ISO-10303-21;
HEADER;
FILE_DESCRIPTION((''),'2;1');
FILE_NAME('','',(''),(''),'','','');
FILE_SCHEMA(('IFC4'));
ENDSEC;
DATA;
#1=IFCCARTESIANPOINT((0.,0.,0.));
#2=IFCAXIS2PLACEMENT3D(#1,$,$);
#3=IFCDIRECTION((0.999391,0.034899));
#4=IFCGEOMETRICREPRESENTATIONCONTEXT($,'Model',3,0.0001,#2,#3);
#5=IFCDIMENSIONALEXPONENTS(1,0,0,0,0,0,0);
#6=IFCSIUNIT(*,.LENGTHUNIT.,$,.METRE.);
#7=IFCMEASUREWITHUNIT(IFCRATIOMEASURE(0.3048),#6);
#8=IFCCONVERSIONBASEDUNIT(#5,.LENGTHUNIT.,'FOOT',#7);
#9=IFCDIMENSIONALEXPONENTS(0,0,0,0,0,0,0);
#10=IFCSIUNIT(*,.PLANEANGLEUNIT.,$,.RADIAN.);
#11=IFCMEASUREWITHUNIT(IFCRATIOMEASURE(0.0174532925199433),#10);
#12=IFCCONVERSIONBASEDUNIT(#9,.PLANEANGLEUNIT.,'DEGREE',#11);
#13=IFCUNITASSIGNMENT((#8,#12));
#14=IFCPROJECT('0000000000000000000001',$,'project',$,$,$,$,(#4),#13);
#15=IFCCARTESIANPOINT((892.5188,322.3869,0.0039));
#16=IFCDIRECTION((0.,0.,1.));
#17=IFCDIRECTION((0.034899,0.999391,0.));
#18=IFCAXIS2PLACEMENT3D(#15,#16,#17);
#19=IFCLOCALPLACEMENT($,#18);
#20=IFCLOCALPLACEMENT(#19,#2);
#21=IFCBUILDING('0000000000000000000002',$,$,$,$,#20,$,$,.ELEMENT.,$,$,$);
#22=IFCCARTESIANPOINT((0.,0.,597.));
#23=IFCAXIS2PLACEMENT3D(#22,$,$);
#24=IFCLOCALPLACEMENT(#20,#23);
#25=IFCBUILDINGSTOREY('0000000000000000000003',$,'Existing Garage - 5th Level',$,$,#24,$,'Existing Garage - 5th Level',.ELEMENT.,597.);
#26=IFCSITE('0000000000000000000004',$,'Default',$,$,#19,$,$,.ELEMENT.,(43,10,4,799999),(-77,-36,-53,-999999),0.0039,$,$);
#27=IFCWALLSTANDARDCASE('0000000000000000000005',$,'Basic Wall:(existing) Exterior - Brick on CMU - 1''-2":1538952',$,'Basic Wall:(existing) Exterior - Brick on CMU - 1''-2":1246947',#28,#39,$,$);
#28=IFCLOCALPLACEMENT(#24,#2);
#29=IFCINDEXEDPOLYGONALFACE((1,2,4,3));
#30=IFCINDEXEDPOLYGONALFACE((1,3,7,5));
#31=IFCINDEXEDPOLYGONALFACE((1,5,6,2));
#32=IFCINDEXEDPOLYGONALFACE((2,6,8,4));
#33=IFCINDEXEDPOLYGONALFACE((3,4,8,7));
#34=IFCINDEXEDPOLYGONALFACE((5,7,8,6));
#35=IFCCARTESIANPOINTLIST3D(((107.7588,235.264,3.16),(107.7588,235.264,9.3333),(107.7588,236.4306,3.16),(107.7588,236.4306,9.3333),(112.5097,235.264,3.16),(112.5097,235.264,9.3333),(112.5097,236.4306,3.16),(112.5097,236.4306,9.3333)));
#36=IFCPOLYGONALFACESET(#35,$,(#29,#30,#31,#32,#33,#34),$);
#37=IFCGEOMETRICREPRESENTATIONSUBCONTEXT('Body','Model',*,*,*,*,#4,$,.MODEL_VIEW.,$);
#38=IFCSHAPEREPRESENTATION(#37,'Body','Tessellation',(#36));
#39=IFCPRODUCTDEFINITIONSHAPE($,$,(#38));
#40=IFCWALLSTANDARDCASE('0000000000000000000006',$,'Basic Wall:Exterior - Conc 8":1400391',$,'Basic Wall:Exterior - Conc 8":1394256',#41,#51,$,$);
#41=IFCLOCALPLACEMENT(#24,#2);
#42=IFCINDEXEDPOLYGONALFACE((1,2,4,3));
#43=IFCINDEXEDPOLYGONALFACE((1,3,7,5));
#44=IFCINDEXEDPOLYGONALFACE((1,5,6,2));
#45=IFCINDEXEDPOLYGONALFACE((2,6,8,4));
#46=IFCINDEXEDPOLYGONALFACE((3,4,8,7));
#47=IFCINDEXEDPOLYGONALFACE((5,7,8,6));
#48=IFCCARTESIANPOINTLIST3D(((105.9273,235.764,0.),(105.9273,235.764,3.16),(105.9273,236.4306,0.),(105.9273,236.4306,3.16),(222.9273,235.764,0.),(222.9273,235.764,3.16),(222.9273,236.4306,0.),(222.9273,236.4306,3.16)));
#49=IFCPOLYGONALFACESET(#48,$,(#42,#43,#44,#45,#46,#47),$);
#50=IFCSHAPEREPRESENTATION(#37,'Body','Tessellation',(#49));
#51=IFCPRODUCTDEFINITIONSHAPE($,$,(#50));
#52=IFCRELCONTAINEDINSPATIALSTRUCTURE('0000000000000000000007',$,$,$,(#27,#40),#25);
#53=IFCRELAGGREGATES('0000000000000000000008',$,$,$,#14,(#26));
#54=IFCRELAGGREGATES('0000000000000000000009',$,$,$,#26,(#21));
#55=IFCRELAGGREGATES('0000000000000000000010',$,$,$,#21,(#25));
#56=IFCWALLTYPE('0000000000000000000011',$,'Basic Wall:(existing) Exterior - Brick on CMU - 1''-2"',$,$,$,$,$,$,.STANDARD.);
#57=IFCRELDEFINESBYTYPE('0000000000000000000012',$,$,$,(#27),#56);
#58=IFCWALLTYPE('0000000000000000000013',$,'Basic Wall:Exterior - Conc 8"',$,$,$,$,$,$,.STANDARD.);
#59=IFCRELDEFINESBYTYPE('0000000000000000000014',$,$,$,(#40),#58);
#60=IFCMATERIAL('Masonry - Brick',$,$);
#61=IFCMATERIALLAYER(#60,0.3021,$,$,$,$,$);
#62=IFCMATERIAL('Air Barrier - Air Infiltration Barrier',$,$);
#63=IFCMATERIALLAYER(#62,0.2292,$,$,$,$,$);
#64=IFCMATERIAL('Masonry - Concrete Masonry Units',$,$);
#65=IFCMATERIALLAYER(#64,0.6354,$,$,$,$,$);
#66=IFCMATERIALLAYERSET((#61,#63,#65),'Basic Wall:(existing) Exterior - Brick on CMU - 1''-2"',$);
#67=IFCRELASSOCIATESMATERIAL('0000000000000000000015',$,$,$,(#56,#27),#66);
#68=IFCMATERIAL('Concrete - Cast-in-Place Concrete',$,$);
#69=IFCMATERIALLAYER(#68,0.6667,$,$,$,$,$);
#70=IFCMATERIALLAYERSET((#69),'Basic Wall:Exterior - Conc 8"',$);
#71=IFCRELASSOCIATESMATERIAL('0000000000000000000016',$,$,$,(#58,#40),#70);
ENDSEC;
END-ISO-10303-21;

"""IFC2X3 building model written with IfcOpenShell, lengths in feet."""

from ifc_helpers import new_model, entity, si_unit, converted_unit, direction, frame, frame_2d, origin, place, context, subcontext, project, spatial, rectangle, extrude, material, layer, layer_set, layer_usage, type_object, element, save


model = new_model("IFC2X3")

# Units and contexts
model_context = context("Model", 3, precision=0.0001, world=origin(), true_north=direction((0.999391, 0.034899)))
body_context = subcontext(model_context, "Body", "Model", "MODEL_VIEW")
ifc_project = project(units=[converted_unit("LENGTHUNIT", "FOOT", entity("IfcRatioMeasure", 0.3048), si_unit("LENGTHUNIT", "METRE"), dimensions=[1, 0, 0, 0, 0, 0, 0]), converted_unit("PLANEANGLEUNIT", "DEGREE", entity("IfcRatioMeasure", 0.0174532925199433), si_unit("PLANEANGLEUNIT", "RADIAN"), dimensions=[0, 0, 0, 0, 0, 0, 0])], contexts=[model_context])

# Site, building, storey
site_placement = place(None, frame((892.5188, 322.3869, 0.0039), z_axis=(0.0, 0.0, 1.0), x_axis=(0.034899, 0.999391, 0.0)))
site = spatial("IfcSite", under=ifc_project, at=site_placement, Name="Default", CompositionType="ELEMENT", RefLatitude=(43, 10, 4, 799999), RefLongitude=(-77, -36, -53, -999999), RefElevation=0.0039)
building_placement = place(site_placement, origin())
building = spatial("IfcBuilding", under=site, at=building_placement, CompositionType="ELEMENT")
storey_placement = place(building_placement, frame((0.0, 0.0, 597.0)))
storey = spatial("IfcBuildingStorey", under=building, at=storey_placement, Name="Existing Garage - 5th Level", LongName="Existing Garage - 5th Level", CompositionType="ELEMENT", Elevation=597.0)

# Shared definitions
ifc_material_1 = material(Name="Concrete - Cast-in-Place Concrete")

# Walls
ifc_material_2 = material(Name="Masonry - Brick")
ifc_layer_1 = layer(ifc_material_2, 0.3021)
ifc_material_3 = material(Name="Air Barrier - Air Infiltration Barrier")
ifc_layer_2 = layer(ifc_material_3, 0.2292)
ifc_material_4 = material(Name="Masonry - Concrete Masonry Units")
ifc_layer_3 = layer(ifc_material_4, 0.6354)
ifc_layer_set_1 = layer_set([ifc_layer_1, ifc_layer_2, ifc_layer_3], Name="Basic Wall:(existing) Exterior - Brick on CMU - 1'-2\"")
ifc_layer_usage_1 = layer_usage(ifc_layer_set_1, "AXIS2", "POSITIVE", -0.5833)
wall_type_1 = type_object("IfcWallType", Name="Basic Wall:(existing) Exterior - Brick on CMU - 1'-2\"", PredefinedType="STANDARD", material=ifc_layer_set_1)
wall_1_placement = place(storey_placement, frame((107.7588, 235.8473, 3.16)))
element("IfcWallStandardCase", 1, at=wall_1_placement, inside=storey, type_object=wall_type_1, material=ifc_layer_usage_1, Name="Basic Wall:(existing) Exterior - Brick on CMU - 1'-2\":1538952", ObjectType="Basic Wall:(existing) Exterior - Brick on CMU - 1'-2\":1246947", context=body_context, shape_type="SweptSolid", body=[
    extrude(rectangle(XDim=4.7509, YDim=1.1667, at=frame_2d((2.3755, 0.0), x_axis=(-1.0, 0.0))), origin(), (0.0, 0.0, 1.0), 6.1733),
])
ifc_layer_4 = layer(ifc_material_1, 0.6667)
ifc_layer_set_2 = layer_set([ifc_layer_4], Name="Basic Wall:Exterior - Conc 8\"")
ifc_layer_usage_2 = layer_usage(ifc_layer_set_2, "AXIS2", "NEGATIVE", 0.3333)
wall_type_2 = type_object("IfcWallType", Name="Basic Wall:Exterior - Conc 8\"", PredefinedType="STANDARD", material=ifc_layer_set_2)
wall_2_placement = place(storey_placement, frame((222.9273, 236.0973, 0.0), z_axis=(0.0, 0.0, 1.0), x_axis=(-1.0, 0.0, 0.0)))
element("IfcWallStandardCase", 2, at=wall_2_placement, inside=storey, type_object=wall_type_2, material=ifc_layer_usage_2, Name="Basic Wall:Exterior - Conc 8\":1400391", ObjectType="Basic Wall:Exterior - Conc 8\":1394256", context=body_context, shape_type="SweptSolid", body=[
    extrude(rectangle(XDim=117.0, YDim=0.6667, at=frame_2d((58.5, 0.0), x_axis=(-1.0, 0.0))), origin(), (0.0, 0.0, 1.0), 3.16),
])

save(model, "model.ifc")
